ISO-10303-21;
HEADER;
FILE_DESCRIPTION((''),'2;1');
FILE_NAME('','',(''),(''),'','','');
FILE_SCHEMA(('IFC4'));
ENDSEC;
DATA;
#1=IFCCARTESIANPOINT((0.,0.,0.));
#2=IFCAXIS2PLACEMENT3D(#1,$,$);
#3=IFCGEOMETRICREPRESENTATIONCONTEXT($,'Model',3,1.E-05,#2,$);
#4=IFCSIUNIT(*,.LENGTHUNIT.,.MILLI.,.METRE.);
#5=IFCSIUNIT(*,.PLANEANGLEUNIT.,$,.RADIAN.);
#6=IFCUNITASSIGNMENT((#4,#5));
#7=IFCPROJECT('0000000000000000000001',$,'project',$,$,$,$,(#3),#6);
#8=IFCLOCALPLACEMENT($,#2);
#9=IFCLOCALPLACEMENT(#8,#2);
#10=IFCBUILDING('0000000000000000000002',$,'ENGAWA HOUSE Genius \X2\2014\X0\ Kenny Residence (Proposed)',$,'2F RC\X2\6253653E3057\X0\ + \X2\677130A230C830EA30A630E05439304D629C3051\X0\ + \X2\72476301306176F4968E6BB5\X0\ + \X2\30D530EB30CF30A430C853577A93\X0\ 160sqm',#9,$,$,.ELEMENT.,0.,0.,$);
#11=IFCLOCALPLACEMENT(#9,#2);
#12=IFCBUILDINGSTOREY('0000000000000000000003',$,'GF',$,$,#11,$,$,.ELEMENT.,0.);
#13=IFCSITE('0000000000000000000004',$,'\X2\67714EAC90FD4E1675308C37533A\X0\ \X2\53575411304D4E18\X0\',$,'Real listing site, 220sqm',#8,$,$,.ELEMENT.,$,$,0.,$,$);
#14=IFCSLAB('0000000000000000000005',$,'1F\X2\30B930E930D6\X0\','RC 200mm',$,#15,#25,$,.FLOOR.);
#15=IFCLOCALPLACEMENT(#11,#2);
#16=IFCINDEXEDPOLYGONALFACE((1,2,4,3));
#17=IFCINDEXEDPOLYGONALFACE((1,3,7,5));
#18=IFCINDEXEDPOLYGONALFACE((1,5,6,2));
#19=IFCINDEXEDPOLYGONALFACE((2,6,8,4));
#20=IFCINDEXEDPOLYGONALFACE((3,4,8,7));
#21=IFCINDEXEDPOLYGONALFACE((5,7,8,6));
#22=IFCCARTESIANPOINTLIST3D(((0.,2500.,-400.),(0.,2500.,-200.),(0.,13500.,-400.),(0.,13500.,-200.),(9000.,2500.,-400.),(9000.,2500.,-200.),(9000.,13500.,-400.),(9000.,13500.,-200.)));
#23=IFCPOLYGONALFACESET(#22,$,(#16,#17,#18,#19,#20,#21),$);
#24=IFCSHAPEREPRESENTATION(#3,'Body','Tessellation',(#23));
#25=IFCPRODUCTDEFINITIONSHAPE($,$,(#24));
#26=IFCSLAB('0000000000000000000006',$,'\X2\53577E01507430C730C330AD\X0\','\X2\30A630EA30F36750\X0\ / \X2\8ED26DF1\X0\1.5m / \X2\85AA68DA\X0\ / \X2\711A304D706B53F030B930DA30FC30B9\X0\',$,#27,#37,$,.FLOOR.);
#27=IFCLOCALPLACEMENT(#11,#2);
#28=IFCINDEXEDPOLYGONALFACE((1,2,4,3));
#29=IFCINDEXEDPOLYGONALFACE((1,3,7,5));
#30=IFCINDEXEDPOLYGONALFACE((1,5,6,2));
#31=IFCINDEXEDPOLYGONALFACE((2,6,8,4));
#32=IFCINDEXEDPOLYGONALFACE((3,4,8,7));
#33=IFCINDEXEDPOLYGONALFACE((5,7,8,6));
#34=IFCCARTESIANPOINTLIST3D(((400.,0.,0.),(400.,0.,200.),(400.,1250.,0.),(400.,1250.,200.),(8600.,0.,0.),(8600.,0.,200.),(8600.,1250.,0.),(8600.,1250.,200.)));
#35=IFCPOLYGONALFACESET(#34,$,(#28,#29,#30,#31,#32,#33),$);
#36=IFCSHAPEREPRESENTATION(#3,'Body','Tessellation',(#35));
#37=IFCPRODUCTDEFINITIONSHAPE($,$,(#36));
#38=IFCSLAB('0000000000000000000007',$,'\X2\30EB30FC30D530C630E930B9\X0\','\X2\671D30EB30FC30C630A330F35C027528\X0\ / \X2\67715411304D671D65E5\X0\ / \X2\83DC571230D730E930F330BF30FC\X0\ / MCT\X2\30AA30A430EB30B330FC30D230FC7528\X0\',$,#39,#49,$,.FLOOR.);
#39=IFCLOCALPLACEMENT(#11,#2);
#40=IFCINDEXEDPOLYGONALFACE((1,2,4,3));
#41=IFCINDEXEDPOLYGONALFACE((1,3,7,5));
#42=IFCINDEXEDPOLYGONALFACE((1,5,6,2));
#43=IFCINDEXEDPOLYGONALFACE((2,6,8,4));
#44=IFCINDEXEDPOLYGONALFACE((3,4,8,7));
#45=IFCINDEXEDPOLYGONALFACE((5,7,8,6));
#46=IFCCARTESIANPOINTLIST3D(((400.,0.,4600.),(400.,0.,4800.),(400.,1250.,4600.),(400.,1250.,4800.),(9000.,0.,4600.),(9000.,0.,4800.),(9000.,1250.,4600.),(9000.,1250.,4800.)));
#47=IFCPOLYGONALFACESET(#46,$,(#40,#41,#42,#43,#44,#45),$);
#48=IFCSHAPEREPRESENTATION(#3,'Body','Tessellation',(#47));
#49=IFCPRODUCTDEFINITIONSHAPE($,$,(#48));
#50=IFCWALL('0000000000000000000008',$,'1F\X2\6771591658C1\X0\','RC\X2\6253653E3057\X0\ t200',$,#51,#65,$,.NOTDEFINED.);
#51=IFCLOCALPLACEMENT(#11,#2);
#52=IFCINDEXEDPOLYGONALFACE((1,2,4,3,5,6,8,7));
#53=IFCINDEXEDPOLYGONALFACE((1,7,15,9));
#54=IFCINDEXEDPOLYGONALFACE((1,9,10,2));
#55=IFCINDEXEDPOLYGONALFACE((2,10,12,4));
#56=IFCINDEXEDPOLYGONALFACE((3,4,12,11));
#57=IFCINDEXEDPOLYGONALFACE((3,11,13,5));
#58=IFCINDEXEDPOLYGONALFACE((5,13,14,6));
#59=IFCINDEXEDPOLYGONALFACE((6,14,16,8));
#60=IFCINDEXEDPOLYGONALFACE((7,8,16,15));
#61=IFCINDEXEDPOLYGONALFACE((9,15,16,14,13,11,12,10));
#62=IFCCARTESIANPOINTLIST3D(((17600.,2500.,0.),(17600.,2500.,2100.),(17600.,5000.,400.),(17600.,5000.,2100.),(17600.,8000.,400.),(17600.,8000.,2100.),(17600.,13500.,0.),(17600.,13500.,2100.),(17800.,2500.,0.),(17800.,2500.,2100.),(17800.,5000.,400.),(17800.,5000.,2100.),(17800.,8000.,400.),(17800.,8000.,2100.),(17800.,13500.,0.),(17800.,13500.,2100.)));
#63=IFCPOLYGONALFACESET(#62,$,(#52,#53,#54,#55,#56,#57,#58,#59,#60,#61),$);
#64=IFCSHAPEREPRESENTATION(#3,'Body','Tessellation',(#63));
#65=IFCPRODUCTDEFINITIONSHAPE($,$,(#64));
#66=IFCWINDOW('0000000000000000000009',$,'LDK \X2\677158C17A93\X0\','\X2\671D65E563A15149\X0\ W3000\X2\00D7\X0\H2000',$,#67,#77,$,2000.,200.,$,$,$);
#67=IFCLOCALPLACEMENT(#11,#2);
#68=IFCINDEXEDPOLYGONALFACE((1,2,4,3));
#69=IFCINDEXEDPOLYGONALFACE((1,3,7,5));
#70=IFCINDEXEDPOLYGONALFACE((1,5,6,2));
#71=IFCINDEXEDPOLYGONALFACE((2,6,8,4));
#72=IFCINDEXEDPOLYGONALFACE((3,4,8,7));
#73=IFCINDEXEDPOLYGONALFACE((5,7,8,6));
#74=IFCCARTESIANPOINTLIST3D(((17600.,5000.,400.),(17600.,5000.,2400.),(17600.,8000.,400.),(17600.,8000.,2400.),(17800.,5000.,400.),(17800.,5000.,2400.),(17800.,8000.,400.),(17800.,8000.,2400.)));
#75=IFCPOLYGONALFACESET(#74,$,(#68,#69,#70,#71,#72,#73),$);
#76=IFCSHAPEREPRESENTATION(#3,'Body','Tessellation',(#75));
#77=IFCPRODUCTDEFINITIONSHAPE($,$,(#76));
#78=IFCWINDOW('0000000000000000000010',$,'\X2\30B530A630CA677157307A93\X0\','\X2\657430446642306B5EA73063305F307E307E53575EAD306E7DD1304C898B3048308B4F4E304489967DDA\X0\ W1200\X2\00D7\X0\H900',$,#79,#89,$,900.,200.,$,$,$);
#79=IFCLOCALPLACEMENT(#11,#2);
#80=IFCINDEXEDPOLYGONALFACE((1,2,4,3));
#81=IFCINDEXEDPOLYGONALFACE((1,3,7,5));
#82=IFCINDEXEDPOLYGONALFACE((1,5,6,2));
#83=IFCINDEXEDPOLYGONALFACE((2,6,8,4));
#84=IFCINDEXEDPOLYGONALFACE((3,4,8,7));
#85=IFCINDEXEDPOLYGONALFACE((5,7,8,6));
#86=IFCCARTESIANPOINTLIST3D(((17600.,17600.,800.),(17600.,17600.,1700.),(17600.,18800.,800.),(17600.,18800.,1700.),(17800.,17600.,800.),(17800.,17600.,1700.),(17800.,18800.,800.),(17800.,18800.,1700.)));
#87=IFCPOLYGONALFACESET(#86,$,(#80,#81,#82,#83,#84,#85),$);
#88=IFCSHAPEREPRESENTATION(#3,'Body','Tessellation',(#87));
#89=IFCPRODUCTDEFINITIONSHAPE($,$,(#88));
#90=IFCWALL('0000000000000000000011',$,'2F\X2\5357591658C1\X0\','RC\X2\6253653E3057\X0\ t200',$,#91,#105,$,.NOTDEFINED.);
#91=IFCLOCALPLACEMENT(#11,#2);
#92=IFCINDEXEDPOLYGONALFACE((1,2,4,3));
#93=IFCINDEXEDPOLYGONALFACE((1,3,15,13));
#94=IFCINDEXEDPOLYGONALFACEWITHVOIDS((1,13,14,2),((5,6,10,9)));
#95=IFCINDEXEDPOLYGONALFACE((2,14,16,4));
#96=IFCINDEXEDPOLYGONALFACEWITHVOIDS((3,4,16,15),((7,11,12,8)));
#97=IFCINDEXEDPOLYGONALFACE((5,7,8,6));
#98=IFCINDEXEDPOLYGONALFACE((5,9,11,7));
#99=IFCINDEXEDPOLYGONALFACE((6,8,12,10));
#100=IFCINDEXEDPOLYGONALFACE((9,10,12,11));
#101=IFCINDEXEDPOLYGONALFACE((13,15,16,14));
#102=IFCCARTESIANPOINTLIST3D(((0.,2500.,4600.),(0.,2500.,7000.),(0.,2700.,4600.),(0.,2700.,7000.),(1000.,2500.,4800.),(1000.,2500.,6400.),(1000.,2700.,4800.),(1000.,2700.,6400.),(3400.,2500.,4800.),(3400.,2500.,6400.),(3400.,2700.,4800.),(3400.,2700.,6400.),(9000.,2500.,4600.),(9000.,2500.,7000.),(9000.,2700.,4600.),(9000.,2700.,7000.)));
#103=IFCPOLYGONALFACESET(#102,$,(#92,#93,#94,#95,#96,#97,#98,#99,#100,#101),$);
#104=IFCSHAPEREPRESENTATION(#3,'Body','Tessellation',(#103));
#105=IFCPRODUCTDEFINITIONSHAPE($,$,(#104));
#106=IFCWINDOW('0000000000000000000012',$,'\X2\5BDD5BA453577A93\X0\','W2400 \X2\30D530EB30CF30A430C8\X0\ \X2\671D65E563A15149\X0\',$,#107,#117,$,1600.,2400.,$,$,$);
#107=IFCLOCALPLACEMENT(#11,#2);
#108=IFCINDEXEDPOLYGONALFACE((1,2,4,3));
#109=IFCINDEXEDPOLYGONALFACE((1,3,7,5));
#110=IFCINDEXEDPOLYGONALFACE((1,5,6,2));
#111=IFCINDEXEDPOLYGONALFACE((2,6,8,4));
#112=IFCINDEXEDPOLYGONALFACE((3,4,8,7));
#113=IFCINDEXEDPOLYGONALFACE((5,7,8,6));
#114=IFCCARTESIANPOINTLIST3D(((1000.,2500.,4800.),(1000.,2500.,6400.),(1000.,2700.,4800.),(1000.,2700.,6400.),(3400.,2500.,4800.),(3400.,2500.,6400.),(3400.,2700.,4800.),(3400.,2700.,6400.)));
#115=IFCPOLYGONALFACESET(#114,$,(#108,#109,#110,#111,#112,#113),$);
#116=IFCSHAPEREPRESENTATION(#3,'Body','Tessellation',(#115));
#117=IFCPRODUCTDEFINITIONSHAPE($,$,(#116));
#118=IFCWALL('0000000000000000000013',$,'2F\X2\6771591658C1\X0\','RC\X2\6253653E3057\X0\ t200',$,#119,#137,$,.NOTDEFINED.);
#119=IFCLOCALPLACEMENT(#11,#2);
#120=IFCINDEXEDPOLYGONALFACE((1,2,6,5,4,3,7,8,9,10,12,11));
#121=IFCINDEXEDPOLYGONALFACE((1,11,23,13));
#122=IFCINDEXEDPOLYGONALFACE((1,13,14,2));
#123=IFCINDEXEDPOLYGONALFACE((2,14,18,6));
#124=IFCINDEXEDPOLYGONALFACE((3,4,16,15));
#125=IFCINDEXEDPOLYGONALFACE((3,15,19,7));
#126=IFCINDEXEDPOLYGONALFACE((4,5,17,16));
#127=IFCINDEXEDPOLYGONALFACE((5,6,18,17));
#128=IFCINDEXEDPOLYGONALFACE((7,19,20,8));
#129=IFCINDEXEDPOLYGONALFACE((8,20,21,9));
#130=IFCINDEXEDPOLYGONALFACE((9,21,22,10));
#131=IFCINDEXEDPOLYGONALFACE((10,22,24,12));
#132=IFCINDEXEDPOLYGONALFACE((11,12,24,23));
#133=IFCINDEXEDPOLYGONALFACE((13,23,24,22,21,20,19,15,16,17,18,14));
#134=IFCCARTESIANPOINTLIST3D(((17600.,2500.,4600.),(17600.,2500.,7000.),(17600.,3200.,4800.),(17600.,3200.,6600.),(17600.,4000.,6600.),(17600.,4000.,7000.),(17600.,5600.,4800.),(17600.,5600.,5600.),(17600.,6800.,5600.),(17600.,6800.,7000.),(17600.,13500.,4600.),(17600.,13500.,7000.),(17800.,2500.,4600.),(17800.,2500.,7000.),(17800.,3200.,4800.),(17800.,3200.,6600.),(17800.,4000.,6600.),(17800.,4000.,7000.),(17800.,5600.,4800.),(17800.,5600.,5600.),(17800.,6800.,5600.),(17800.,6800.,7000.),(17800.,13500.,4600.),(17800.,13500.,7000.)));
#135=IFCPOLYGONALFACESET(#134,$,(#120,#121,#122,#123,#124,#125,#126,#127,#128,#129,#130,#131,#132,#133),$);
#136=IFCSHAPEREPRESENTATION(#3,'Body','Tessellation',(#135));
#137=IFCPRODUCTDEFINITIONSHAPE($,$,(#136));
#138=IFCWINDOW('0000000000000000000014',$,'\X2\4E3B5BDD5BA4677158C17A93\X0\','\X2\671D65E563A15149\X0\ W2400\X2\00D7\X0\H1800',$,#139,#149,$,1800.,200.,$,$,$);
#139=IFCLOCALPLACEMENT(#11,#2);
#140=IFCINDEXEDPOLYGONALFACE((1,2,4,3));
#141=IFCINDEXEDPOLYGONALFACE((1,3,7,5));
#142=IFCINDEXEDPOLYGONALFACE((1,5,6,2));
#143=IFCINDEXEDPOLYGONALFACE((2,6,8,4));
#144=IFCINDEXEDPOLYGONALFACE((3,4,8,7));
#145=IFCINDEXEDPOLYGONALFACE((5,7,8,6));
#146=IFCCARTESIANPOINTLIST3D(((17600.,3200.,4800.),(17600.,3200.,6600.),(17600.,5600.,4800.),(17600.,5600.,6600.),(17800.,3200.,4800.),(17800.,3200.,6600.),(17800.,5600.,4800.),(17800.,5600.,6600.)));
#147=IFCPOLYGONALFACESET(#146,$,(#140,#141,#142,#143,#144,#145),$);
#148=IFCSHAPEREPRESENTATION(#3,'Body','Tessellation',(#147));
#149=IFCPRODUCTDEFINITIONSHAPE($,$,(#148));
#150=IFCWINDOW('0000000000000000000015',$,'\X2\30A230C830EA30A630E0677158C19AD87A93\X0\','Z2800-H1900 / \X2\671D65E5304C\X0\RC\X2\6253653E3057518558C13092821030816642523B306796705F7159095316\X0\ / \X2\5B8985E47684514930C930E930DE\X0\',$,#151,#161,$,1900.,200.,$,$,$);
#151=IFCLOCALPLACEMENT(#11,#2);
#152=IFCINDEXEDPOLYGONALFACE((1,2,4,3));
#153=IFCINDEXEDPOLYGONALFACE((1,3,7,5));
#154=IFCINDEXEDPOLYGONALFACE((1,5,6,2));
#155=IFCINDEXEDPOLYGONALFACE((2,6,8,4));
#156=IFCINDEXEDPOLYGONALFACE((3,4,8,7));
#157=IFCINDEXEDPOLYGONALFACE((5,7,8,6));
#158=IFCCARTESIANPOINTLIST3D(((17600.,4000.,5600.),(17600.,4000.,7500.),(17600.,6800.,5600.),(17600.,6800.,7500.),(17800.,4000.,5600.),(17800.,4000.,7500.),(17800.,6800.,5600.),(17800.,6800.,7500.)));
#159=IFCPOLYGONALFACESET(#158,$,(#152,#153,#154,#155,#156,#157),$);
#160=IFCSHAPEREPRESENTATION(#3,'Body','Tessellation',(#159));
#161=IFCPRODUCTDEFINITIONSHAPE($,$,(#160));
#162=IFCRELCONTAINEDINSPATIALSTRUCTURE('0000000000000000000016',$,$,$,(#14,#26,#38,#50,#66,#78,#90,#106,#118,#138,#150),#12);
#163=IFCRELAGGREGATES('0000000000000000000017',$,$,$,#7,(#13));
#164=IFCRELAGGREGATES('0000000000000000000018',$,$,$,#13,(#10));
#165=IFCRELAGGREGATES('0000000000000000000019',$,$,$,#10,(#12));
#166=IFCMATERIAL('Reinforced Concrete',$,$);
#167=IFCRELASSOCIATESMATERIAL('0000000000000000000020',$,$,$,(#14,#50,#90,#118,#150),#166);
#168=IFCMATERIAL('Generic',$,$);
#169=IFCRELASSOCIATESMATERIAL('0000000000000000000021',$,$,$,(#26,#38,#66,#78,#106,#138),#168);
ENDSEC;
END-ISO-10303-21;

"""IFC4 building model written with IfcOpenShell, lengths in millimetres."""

from ifc_helpers import new_model, si_unit, frame, frame_2d, origin, place, context, project, spatial, rectangle, extrude, material, element, fill, save


model = new_model("IFC4")

# Units and contexts
model_context = context("Model", 3, precision=1e-05, world=origin())
ifc_project = project(units=[si_unit("LENGTHUNIT", "METRE", prefix="MILLI"), si_unit("PLANEANGLEUNIT", "RADIAN")], contexts=[model_context])

# Site, building, storey
site_placement = place(None, origin())
site = spatial("IfcSite", under=ifc_project, at=site_placement, Name="東京都世田谷区 南向き丘", ObjectType="Real listing site, 220sqm", CompositionType="ELEMENT", RefElevation=0.0)
building_placement = place(site_placement, origin())
building = spatial("IfcBuilding", under=site, at=building_placement, Name="ENGAWA HOUSE Genius — Kenny Residence (Proposed)", ObjectType="2F RC打放し + 東アトリウム吹き抜け + 片持ち直階段 + フルハイト南窓 160sqm", CompositionType="ELEMENT", ElevationOfRefHeight=0.0, ElevationOfTerrain=0.0)
storey_placement = place(building_placement, origin())
storey = spatial("IfcBuildingStorey", under=building, at=storey_placement, Name="GF", CompositionType="ELEMENT", Elevation=0.0)

# Shared definitions
ifc_material_1 = material(Name="Generic")

# Slabs
ifc_material_2 = material(Name="Reinforced Concrete")
slab_1_placement = place(storey_placement, frame((0.0, 1250.0, -200.0)))
element("IfcSlab", 1, at=slab_1_placement, inside=storey, material=ifc_material_2, Name="1Fスラブ", Description="RC 200mm", PredefinedType="FLOOR", context=model_context, shape_type="SweptSolid", body=[
    extrude(rectangle(XDim=9000.0, YDim=11000.0, at=frame_2d((4500.0, 5500.0))), frame((0.0, 1250.0, -200.0)), (0.0, 0.0, 1.0), 200.0),
])
slab_2_placement = place(storey_placement, frame((200.0, 0.0, 0.0)))
element("IfcSlab", 2, at=slab_2_placement, inside=storey, material=ifc_material_1, Name="南縁側デッキ", Description="ウリン材 / 軒深1.5m / 薪棚 / 焚き火台スペース", PredefinedType="FLOOR", context=model_context, shape_type="SweptSolid", body=[
    extrude(rectangle(XDim=8200.0, YDim=1250.0, at=frame_2d((4100.0, 625.0))), frame((200.0, 0.0, 0.0)), (0.0, 0.0, 1.0), 200.0),
])
slab_3_placement = place(storey_placement, frame((200.0, 0.0, 2300.0)))
element("IfcSlab", 3, at=slab_3_placement, inside=storey, material=ifc_material_1, Name="ルーフテラス", Description="朝ルーティン専用 / 東向き朝日 / 菜園プランター / MCTオイルコーヒー用", PredefinedType="FLOOR", context=model_context, shape_type="SweptSolid", body=[
    extrude(rectangle(XDim=8600.0, YDim=1250.0, at=frame_2d((4300.0, 625.0))), frame((200.0, 0.0, 2300.0)), (0.0, 0.0, 1.0), 200.0),
])

# Wall, openings, windows
wall_1_placement = place(storey_placement, frame((8800.0, 1250.0, 0.0)))
wall_1 = element("IfcWall", 4, at=wall_1_placement, inside=storey, material=ifc_material_2, Name="1F東外壁", Description="RC打放し t200", PredefinedType="NOTDEFINED", context=model_context, shape_type="SweptSolid", body=[
    extrude(rectangle(XDim=200.0, YDim=11000.0, at=frame_2d((100.0, 5500.0))), frame((8800.0, 1250.0, 0.0)), (0.0, 0.0, 1.0), 2100.0),
])
opening_1_placement = place(storey_placement, frame((8800.0, 2500.0, 200.0)))
opening_1 = element("IfcOpeningElement", 5, at=opening_1_placement, cuts=wall_1, PredefinedType="NOTDEFINED", context=model_context, shape_type="SweptSolid", body=[
    extrude(rectangle(XDim=200.0, YDim=3000.0, at=frame_2d((100.0, 1500.0))), frame((8800.0, 2500.0, 200.0)), (0.0, 0.0, 1.0), 2000.0),
])
opening_2_placement = place(storey_placement, frame((8800.0, 8800.0, 400.0)))
opening_2 = element("IfcOpeningElement", 6, at=opening_2_placement, cuts=wall_1, PredefinedType="NOTDEFINED", context=model_context, shape_type="SweptSolid", body=[
    extrude(rectangle(XDim=200.0, YDim=1200.0, at=frame_2d((100.0, 600.0))), frame((8800.0, 8800.0, 400.0)), (0.0, 0.0, 1.0), 900.0),
])
window_1_placement = place(storey_placement, frame((8800.0, 2500.0, 200.0)))
window_1 = element("IfcWindow", 7, at=window_1_placement, inside=storey, material=ifc_material_1, Name="LDK 東壁窓", Description="朝日採光 W3000×H2000", OverallHeight=2000.0, OverallWidth=200.0, context=model_context, shape_type="SweptSolid", body=[
    extrude(rectangle(XDim=200.0, YDim=3000.0, at=frame_2d((100.0, 1500.0))), frame((8800.0, 2500.0, 200.0)), (0.0, 0.0, 1.0), 2000.0),
])
fill(opening_1, window_1)
window_2_placement = place(storey_placement, frame((8800.0, 8800.0, 400.0)))
window_2 = element("IfcWindow", 8, at=window_2_placement, inside=storey, material=ifc_material_1, Name="サウナ東地窓", Description="整い時に座ったまま南庭の緑が見える低い視線 W1200×H900", OverallHeight=900.0, OverallWidth=200.0, context=model_context, shape_type="SweptSolid", body=[
    extrude(rectangle(XDim=200.0, YDim=1200.0, at=frame_2d((100.0, 600.0))), frame((8800.0, 8800.0, 400.0)), (0.0, 0.0, 1.0), 900.0),
])
fill(opening_2, window_2)

# Wall, opening, window
wall_2_placement = place(storey_placement, frame((0.0, 1250.0, 2300.0)))
wall_2 = element("IfcWall", 9, at=wall_2_placement, inside=storey, material=ifc_material_2, Name="2F南外壁", Description="RC打放し t200", PredefinedType="NOTDEFINED", context=model_context, shape_type="SweptSolid", body=[
    extrude(rectangle(XDim=9000.0, YDim=200.0, at=frame_2d((4500.0, 100.0))), frame((0.0, 1250.0, 2300.0)), (0.0, 0.0, 1.0), 2400.0),
])
opening_3_placement = place(storey_placement, frame((500.0, 1250.0, 2400.0)))
opening_3 = element("IfcOpeningElement", 10, at=opening_3_placement, cuts=wall_2, PredefinedType="NOTDEFINED", context=model_context, shape_type="SweptSolid", body=[
    extrude(rectangle(XDim=2400.0, YDim=200.0, at=frame_2d((1200.0, 100.0))), frame((500.0, 1250.0, 2400.0)), (0.0, 0.0, 1.0), 1600.0),
])
window_3_placement = place(storey_placement, frame((500.0, 1250.0, 2400.0)))
window_3 = element("IfcWindow", 11, at=window_3_placement, inside=storey, material=ifc_material_1, Name="寝室南窓", Description="W2400 フルハイト 朝日採光", OverallHeight=1600.0, OverallWidth=2400.0, context=model_context, shape_type="SweptSolid", body=[
    extrude(rectangle(XDim=2400.0, YDim=200.0, at=frame_2d((1200.0, 100.0))), frame((500.0, 1250.0, 2400.0)), (0.0, 0.0, 1.0), 1600.0),
])
fill(opening_3, window_3)

# Wall, openings, windows
wall_3_placement = place(storey_placement, frame((8800.0, 1250.0, 2300.0)))
wall_3 = element("IfcWall", 12, at=wall_3_placement, inside=storey, material=ifc_material_2, Name="2F東外壁", Description="RC打放し t200", PredefinedType="NOTDEFINED", context=model_context, shape_type="SweptSolid", body=[
    extrude(rectangle(XDim=200.0, YDim=11000.0, at=frame_2d((100.0, 5500.0))), frame((8800.0, 1250.0, 2300.0)), (0.0, 0.0, 1.0), 2400.0),
])
opening_4_placement = place(storey_placement, frame((8800.0, 1600.0, 2400.0)))
opening_4 = element("IfcOpeningElement", 13, at=opening_4_placement, cuts=wall_3, PredefinedType="NOTDEFINED", context=model_context, shape_type="SweptSolid", body=[
    extrude(rectangle(XDim=200.0, YDim=2400.0, at=frame_2d((100.0, 1200.0))), frame((8800.0, 1600.0, 2400.0)), (0.0, 0.0, 1.0), 1800.0),
])
opening_5_placement = place(storey_placement, frame((8800.0, 2000.0, 2800.0)))
opening_5 = element("IfcOpeningElement", 14, at=opening_5_placement, cuts=wall_3, PredefinedType="NOTDEFINED", context=model_context, shape_type="SweptSolid", body=[
    extrude(rectangle(XDim=200.0, YDim=2800.0, at=frame_2d((100.0, 1400.0))), frame((8800.0, 2000.0, 2800.0)), (0.0, 0.0, 1.0), 1900.0),
])
window_4_placement = place(storey_placement, frame((8800.0, 1600.0, 2400.0)))
window_4 = element("IfcWindow", 15, at=window_4_placement, inside=storey, material=ifc_material_1, Name="主寝室東壁窓", Description="朝日採光 W2400×H1800", OverallHeight=1800.0, OverallWidth=200.0, context=model_context, shape_type="SweptSolid", body=[
    extrude(rectangle(XDim=200.0, YDim=2400.0, at=frame_2d((100.0, 1200.0))), frame((8800.0, 1600.0, 2400.0)), (0.0, 0.0, 1.0), 1800.0),
])
fill(opening_4, window_4)
window_5_placement = place(storey_placement, frame((8800.0, 2000.0, 2800.0)))
window_5 = element("IfcWindow", 16, at=window_5_placement, inside=storey, material=ifc_material_2, Name="アトリウム東壁高窓", Description="Z2800-H1900 / 朝日がRC打放し内壁を舐め時刻で陰影変化 / 安藤的光ドラマ", OverallHeight=1900.0, OverallWidth=200.0, context=model_context, shape_type="SweptSolid", body=[
    extrude(rectangle(XDim=200.0, YDim=2800.0, at=frame_2d((100.0, 1400.0))), frame((8800.0, 2000.0, 2800.0)), (0.0, 0.0, 1.0), 1900.0),
])
fill(opening_5, window_5)

save(model, "model.ifc")
